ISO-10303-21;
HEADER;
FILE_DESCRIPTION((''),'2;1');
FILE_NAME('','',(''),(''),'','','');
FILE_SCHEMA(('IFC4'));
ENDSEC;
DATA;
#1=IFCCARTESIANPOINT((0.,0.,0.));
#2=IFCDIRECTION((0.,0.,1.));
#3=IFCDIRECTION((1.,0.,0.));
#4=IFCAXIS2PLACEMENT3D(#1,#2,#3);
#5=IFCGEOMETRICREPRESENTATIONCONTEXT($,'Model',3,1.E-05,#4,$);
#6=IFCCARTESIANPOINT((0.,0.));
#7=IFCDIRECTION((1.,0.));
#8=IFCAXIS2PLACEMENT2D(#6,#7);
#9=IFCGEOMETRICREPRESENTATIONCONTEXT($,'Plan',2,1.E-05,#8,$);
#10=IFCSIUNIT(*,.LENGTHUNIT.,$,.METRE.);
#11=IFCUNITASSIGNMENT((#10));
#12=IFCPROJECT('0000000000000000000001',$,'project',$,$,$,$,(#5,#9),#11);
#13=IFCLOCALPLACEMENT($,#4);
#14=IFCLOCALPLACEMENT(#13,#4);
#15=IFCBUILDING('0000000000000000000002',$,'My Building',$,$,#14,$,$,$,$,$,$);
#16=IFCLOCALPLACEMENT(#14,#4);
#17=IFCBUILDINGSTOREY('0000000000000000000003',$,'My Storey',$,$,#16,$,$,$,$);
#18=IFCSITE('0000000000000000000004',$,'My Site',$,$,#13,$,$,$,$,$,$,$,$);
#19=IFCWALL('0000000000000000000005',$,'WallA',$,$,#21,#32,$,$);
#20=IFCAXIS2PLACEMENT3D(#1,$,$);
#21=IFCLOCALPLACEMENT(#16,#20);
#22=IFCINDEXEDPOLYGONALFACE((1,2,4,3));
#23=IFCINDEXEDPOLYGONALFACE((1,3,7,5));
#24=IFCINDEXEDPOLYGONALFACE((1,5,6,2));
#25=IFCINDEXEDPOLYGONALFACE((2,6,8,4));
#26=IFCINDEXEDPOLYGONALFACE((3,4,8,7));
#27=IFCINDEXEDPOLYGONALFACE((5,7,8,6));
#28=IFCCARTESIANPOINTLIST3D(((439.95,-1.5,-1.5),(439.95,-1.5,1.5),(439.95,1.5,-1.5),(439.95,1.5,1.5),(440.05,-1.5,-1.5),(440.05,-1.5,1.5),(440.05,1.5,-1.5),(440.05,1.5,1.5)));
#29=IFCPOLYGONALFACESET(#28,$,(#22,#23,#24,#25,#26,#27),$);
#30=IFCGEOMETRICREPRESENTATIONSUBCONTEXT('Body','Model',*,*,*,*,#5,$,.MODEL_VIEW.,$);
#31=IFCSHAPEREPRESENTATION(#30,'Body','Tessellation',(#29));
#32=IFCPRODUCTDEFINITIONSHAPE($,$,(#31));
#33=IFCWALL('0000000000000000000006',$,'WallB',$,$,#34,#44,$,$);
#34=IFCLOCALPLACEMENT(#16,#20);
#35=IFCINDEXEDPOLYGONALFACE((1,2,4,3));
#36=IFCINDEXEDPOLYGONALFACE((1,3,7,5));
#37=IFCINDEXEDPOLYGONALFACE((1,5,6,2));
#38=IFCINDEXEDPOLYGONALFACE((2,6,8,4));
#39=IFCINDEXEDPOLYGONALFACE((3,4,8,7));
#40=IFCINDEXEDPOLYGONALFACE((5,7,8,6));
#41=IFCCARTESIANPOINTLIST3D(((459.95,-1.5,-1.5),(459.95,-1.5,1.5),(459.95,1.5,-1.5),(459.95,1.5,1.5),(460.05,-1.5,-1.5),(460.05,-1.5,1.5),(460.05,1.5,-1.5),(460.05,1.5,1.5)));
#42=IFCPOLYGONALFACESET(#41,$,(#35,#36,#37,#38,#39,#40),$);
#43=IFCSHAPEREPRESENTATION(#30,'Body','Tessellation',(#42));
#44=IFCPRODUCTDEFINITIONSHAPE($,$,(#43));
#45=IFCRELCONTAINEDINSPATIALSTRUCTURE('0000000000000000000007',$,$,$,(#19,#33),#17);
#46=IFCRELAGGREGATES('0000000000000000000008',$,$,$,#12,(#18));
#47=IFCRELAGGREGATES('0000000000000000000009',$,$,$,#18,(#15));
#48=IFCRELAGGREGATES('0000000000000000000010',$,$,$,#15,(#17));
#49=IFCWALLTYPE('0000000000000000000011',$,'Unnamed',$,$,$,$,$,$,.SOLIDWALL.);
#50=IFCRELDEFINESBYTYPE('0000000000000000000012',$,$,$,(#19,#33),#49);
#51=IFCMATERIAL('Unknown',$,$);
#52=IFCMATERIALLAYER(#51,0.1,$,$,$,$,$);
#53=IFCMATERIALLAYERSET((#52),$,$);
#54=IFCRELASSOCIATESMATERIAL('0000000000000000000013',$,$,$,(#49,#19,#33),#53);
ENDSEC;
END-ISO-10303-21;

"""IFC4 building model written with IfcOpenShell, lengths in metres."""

from ifc_helpers import new_model, si_unit, frame, origin_with_axes, origin_2d_with_axis, place, context, subcontext, project, spatial, line, indexed_curve, outline, extrude, material, layer, layer_set, layer_usage, type_object, element, save


model = new_model("IFC4")

# Units and contexts
model_context = context("Model", 3, precision=1e-05, world=origin_with_axes())
plan_context = context("Plan", 2, precision=1e-05, world=origin_2d_with_axis())
body_context = subcontext(model_context, "Body", "Model", "MODEL_VIEW")
ifc_project = project(units=[si_unit("LENGTHUNIT", "METRE")], contexts=[model_context, plan_context])

# Site, building, storey
site_placement = place(None, origin_with_axes())
site = spatial("IfcSite", under=ifc_project, at=site_placement, Name="My Site")
building_placement = place(site_placement, origin_with_axes())
building = spatial("IfcBuilding", under=site, at=building_placement, Name="My Building")
storey_placement = place(building_placement, origin_with_axes())
storey = spatial("IfcBuildingStorey", under=building, at=storey_placement, Name="My Storey")

# Shared definitions
ifc_material = material(Name="Unknown")

# Walls
ifc_layer_1 = layer(ifc_material, 0.1)
ifc_layer_set_1 = layer_set([ifc_layer_1])
ifc_layer_usage_1 = layer_usage(ifc_layer_set_1, "AXIS2", "POSITIVE", 0.0)
wall_type = type_object("IfcWallType", Name="Unnamed", PredefinedType="SOLIDWALL", material=ifc_layer_set_1)
wall_1_placement = place(storey_placement, frame((440.05, -1.5, -1.5), z_axis=(0.0, 0.0, 1.0), x_axis=(0.0, 1.0, 0.0)))
element("IfcWall", 1, at=wall_1_placement, inside=storey, type_object=wall_type, material=ifc_layer_usage_1, Name="WallA", context=body_context, shape_type="SweptSolid", body=[
    extrude(outline(indexed_curve([(0.0, 0.0), (0.0, 0.1), (3.0, 0.1), (3.0, 0.0)], segments=[line(1, 2, 3, 4, 1)])), origin_with_axes(), (0.0, 0.0, 1.0), 3.0),
])
ifc_layer_usage_2 = layer_usage(ifc_layer_set_1, "AXIS2", "POSITIVE", 0.0)
wall_2_placement = place(storey_placement, frame((460.05, -1.5, -1.5), z_axis=(0.0, 0.0, 1.0), x_axis=(0.0, 1.0, 0.0)))
element("IfcWall", 2, at=wall_2_placement, inside=storey, type_object=wall_type, material=ifc_layer_usage_2, Name="WallB", context=body_context, shape_type="SweptSolid", body=[
    extrude(outline(indexed_curve([(0.0, 0.0), (0.0, 0.1), (3.0, 0.1), (3.0, 0.0)], segments=[line(1, 2, 3, 4, 1)])), origin_with_axes(), (0.0, 0.0, 1.0), 3.0),
])

save(model, "model.ifc")
